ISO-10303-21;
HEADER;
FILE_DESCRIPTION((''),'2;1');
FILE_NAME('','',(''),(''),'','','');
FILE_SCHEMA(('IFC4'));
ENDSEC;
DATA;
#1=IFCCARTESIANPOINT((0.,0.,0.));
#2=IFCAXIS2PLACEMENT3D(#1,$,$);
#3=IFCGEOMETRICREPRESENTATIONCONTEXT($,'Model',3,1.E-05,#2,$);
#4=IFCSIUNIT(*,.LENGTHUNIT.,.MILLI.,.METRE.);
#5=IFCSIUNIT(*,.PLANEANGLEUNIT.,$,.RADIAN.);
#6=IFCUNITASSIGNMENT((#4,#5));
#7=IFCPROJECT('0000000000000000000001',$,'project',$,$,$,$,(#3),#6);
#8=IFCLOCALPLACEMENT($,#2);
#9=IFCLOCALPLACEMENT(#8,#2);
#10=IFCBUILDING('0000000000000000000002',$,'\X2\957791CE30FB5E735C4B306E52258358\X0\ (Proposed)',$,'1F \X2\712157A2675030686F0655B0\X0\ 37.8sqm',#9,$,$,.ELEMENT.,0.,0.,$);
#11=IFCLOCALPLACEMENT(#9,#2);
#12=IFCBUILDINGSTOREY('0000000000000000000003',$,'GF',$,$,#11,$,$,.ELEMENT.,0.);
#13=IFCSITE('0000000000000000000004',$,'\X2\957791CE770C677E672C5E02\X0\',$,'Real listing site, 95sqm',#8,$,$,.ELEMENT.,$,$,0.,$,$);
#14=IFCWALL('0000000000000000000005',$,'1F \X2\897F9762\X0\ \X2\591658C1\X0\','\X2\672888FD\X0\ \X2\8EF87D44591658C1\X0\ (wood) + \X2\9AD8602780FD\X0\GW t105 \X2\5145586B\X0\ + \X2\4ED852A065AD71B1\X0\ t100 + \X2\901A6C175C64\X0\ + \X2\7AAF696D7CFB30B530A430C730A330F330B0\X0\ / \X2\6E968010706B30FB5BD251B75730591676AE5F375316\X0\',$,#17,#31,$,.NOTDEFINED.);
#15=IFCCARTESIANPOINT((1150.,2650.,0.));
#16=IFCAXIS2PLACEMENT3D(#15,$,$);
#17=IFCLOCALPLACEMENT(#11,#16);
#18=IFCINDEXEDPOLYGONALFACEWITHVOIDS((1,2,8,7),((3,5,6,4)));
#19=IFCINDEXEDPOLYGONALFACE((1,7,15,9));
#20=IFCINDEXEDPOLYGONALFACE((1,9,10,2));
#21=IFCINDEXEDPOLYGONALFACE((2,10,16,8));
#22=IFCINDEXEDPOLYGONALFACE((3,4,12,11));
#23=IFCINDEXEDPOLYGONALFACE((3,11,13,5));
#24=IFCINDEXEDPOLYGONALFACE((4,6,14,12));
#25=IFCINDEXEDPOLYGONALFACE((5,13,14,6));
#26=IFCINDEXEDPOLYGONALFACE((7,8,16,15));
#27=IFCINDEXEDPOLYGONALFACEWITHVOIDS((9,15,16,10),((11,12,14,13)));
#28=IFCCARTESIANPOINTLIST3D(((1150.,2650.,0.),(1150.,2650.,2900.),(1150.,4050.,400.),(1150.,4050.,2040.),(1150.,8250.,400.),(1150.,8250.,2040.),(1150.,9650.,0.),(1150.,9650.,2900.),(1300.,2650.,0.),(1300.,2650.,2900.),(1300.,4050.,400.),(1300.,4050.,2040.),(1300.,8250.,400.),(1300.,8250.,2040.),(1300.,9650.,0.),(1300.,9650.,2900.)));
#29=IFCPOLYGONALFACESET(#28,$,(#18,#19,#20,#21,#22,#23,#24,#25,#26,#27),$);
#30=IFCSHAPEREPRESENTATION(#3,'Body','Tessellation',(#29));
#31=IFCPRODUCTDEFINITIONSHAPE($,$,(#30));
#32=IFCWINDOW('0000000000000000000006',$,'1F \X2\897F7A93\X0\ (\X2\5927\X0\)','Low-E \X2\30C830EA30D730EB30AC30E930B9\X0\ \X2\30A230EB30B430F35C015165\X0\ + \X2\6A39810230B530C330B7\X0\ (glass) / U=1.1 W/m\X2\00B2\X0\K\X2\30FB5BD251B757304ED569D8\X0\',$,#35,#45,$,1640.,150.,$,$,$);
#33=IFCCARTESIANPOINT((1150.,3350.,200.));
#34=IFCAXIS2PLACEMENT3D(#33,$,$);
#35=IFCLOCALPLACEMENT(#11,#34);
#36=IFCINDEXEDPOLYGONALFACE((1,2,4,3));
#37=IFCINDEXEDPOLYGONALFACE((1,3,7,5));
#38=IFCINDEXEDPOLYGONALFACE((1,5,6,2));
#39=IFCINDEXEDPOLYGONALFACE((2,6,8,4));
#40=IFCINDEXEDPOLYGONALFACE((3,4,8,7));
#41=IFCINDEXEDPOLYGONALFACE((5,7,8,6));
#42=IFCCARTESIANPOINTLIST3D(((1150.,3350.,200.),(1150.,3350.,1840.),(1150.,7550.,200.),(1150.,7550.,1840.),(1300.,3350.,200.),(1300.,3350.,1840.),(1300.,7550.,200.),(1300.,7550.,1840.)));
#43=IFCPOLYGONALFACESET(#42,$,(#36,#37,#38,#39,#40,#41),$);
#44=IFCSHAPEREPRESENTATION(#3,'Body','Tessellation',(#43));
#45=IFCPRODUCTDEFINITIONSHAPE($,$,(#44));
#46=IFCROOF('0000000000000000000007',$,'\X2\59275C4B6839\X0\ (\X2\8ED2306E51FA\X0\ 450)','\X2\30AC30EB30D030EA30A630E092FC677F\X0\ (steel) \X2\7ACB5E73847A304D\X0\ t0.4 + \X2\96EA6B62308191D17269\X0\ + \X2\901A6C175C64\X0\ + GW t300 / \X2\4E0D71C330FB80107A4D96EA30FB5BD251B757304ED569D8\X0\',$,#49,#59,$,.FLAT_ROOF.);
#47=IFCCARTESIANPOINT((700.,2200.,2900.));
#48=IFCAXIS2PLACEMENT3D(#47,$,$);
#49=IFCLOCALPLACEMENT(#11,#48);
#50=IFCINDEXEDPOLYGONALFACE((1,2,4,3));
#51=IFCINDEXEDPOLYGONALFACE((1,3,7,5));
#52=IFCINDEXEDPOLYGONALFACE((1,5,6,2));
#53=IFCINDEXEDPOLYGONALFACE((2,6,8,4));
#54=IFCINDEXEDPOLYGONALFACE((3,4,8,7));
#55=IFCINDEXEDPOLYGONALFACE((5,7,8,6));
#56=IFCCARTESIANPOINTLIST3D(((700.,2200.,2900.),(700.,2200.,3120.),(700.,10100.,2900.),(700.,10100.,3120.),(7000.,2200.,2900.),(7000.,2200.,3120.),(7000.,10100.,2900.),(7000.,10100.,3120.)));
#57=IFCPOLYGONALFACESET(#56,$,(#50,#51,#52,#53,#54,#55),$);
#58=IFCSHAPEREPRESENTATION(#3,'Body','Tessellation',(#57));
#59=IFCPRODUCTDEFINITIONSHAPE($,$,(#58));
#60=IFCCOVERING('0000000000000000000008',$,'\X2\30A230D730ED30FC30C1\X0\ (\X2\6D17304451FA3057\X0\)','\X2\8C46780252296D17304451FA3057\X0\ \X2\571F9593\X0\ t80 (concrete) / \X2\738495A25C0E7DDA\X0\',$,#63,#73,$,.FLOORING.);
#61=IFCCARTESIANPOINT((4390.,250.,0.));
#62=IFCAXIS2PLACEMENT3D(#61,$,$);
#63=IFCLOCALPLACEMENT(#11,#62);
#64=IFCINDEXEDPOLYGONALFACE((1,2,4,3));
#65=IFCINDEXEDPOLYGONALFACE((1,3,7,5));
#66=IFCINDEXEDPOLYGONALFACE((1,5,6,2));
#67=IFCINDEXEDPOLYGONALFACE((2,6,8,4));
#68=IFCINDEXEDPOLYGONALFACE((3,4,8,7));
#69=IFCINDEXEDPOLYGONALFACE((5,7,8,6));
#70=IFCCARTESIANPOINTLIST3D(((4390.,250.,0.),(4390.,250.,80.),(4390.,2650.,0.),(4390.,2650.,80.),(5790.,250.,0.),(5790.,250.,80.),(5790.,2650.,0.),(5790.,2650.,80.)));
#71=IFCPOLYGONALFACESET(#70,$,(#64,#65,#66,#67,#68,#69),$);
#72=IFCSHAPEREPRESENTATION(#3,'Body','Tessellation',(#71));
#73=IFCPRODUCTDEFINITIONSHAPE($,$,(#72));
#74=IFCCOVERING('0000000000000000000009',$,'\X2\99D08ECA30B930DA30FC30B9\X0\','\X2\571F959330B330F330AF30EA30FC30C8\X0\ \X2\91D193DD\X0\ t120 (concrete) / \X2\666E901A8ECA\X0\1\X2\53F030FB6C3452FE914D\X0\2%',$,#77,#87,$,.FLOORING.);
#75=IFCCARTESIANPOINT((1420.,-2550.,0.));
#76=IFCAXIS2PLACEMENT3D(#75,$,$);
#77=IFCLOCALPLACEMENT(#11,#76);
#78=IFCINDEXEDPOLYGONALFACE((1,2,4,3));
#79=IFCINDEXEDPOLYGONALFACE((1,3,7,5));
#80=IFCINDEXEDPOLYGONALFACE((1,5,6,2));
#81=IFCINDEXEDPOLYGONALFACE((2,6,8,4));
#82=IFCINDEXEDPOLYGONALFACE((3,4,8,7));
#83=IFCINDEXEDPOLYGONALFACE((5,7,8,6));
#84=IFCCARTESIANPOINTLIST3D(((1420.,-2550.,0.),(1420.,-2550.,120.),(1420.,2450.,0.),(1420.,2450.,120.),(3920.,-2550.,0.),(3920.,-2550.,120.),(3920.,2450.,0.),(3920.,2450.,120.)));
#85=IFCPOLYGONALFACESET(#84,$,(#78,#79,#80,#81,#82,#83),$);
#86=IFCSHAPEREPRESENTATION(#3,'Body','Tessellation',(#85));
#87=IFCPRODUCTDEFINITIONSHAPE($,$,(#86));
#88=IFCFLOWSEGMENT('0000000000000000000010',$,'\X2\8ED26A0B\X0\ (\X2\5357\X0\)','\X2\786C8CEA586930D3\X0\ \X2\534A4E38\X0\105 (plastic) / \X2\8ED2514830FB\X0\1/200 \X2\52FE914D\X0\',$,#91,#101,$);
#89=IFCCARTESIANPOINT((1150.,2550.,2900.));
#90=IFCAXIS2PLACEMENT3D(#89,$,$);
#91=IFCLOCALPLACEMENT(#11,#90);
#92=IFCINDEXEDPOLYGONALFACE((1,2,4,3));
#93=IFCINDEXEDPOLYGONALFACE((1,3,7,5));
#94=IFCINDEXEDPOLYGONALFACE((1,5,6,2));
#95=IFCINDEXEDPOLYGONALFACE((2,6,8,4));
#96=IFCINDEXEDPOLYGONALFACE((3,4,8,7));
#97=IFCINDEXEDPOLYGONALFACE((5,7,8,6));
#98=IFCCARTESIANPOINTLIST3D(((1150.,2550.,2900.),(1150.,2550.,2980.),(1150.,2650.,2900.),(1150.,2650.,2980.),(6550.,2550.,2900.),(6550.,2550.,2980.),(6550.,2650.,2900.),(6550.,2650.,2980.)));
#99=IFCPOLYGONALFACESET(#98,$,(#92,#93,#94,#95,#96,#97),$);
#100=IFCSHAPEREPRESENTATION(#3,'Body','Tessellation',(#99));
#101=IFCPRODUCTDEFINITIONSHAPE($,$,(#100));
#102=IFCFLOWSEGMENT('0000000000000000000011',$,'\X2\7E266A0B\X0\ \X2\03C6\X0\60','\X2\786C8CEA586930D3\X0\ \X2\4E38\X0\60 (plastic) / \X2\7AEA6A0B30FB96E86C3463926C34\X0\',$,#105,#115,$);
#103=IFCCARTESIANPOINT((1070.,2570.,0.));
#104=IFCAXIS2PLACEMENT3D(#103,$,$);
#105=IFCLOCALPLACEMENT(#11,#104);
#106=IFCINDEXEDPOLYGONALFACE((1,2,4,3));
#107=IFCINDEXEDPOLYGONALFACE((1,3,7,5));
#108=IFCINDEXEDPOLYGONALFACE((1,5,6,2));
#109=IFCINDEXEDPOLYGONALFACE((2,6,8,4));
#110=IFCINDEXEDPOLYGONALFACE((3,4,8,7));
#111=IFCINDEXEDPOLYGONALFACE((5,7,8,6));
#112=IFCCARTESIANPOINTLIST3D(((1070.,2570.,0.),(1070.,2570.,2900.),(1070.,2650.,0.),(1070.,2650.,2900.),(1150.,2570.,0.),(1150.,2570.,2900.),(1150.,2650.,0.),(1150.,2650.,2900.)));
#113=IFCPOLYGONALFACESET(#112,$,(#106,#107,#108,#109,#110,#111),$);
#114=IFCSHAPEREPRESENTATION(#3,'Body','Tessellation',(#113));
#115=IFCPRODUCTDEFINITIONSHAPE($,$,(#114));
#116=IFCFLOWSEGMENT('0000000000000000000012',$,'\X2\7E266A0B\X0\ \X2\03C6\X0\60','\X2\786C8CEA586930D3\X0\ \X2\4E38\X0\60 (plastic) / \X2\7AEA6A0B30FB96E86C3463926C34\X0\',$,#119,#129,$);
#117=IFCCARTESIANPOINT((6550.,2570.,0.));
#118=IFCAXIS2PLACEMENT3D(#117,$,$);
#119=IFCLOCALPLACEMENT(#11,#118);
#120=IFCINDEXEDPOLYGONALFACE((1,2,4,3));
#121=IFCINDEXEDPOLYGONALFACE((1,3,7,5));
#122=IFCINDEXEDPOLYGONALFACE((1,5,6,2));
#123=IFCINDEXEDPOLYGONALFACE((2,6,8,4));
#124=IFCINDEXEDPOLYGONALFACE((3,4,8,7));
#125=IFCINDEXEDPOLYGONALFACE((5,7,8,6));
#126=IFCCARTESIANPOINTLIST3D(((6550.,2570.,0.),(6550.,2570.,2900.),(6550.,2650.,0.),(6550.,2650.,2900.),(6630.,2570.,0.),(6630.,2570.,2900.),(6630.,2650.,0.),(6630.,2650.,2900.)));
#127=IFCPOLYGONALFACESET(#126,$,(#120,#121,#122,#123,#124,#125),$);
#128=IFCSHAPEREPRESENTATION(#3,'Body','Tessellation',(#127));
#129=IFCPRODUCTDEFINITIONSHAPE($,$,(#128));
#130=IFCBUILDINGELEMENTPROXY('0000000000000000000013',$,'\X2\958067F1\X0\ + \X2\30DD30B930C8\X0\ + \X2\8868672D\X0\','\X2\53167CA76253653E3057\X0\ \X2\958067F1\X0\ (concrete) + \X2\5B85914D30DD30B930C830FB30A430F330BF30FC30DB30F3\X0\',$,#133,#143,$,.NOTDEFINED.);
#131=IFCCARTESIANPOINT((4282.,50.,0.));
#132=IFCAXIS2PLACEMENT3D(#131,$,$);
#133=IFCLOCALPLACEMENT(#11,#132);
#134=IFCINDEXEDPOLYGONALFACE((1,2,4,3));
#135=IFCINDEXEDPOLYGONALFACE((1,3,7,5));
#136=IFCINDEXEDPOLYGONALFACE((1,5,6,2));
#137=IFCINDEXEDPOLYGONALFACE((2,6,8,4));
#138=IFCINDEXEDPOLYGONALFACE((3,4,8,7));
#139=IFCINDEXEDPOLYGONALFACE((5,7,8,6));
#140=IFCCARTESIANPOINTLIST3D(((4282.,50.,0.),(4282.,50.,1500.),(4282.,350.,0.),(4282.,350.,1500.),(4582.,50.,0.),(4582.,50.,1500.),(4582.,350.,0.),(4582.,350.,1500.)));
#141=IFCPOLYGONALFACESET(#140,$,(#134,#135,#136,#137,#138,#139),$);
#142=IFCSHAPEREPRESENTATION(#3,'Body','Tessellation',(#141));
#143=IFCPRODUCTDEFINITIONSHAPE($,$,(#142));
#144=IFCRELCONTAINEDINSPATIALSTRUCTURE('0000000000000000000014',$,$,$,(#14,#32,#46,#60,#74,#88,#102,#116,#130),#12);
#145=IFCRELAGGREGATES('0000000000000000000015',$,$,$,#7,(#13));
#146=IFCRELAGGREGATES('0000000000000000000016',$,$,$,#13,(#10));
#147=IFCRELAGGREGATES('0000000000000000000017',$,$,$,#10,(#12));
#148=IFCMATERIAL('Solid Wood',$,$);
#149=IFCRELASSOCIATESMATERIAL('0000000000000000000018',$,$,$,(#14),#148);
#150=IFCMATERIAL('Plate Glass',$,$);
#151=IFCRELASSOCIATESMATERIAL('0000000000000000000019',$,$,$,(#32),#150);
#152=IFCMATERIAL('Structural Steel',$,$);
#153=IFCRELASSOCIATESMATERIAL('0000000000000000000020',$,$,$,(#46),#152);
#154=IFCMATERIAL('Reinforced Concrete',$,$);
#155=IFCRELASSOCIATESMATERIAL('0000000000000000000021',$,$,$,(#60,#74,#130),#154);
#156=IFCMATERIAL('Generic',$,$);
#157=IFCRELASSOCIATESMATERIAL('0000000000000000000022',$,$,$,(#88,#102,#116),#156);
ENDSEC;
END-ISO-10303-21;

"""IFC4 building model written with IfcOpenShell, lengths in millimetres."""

from ifc_helpers import new_model, si_unit, frame, frame_2d, origin, place, context, project, spatial, rectangle, extrude, material, element, fill, save


model = new_model("IFC4")

# Units and contexts
model_context = context("Model", 3, precision=1e-05, world=origin())
ifc_project = project(units=[si_unit("LENGTHUNIT", "METRE", prefix="MILLI"), si_unit("PLANEANGLEUNIT", "RADIAN")], contexts=[model_context])

# Site, building, storey
site_placement = place(None, origin())
site = spatial("IfcSite", under=ifc_project, at=site_placement, Name="長野県松本市", ObjectType="Real listing site, 95sqm", CompositionType="ELEMENT", RefElevation=0.0)
building_placement = place(site_placement, origin())
building = spatial("IfcBuilding", under=site, at=building_placement, Name="長野・平屋の別荘 (Proposed)", ObjectType="1F 無垢材と漆喰 37.8sqm", CompositionType="ELEMENT", ElevationOfRefHeight=0.0, ElevationOfTerrain=0.0)
storey_placement = place(building_placement, origin())
storey = spatial("IfcBuildingStorey", under=building, at=storey_placement, Name="GF", CompositionType="ELEMENT", Elevation=0.0)

# Shared definitions
ifc_material_1 = material(Name="Solid Wood")

# Shared definitions
ifc_material_2 = material(Name="Reinforced Concrete")

# Shared definitions
ifc_material_3 = material(Name="Plate Glass")

# Wall, opening, window
wall_1_placement = place(storey_placement, frame((1150.0, 2650.0, 0.0)))
wall_1 = element("IfcWall", 1, at=wall_1_placement, inside=storey, material=ifc_material_1, Name="1F 西面 外壁", Description="木製 軸組外壁 (wood) + 高性能GW t105 充填 + 付加断熱 t100 + 通気層 + 窯業系サイディング / 準耐火・寒冷地外皮強化", PredefinedType="NOTDEFINED", context=model_context, shape_type="SweptSolid", body=[
    extrude(rectangle(XDim=150.0, YDim=7000.0, at=frame_2d((75.0, 3500.0))), frame((1150.0, 2650.0, 0.0)), (0.0, 0.0, 1.0), 2900.0),
])
opening_1_placement = place(storey_placement, frame((1150.0, 3350.0, 200.0)))
opening_1 = element("IfcOpeningElement", 2, at=opening_1_placement, cuts=wall_1, PredefinedType="NOTDEFINED", context=model_context, shape_type="SweptSolid", body=[
    extrude(rectangle(XDim=150.0, YDim=4200.0, at=frame_2d((75.0, 2100.0))), frame((1150.0, 3350.0, 200.0)), (0.0, 0.0, 1.0), 1640.0),
])
window_1_placement = place(storey_placement, frame((1150.0, 3350.0, 200.0)))
window_1 = element("IfcWindow", 3, at=window_1_placement, inside=storey, material=ifc_material_3, Name="1F 西窓 (大)", Description="Low-E トリプルガラス アルゴン封入 + 樹脂サッシ (glass) / U=1.1 W/m²K・寒冷地仕様", OverallHeight=1640.0, OverallWidth=150.0, context=model_context, shape_type="SweptSolid", body=[
    extrude(rectangle(XDim=150.0, YDim=4200.0, at=frame_2d((75.0, 2100.0))), frame((1150.0, 3350.0, 200.0)), (0.0, 0.0, 1.0), 1640.0),
])
fill(opening_1, window_1)

# Roof
ifc_material_4 = material(Name="Structural Steel")
roof_placement = place(storey_placement, frame((700.0, 2200.0, 2900.0)))
element("IfcRoof", 4, at=roof_placement, inside=storey, material=ifc_material_4, Name="大屋根 (軒の出 450)", Description="ガルバリウム鋼板 (steel) 立平葺き t0.4 + 雪止め金物 + 通気層 + GW t300 / 不燃・耐積雪・寒冷地仕様", PredefinedType="FLAT_ROOF", context=model_context, shape_type="SweptSolid", body=[
    extrude(rectangle(XDim=6300.0, YDim=7900.0, at=frame_2d((3150.0, 3950.0))), frame((700.0, 2200.0, 2900.0)), (0.0, 0.0, 1.0), 220.0),
])

# Coverings
covering_1_placement = place(storey_placement, frame((4390.0, 250.0, 0.0)))
element("IfcCovering", 5, at=covering_1_placement, inside=storey, material=ifc_material_2, Name="アプローチ (洗い出し)", Description="豆砂利洗い出し 土間 t80 (concrete) / 玄関導線", PredefinedType="FLOORING", context=model_context, shape_type="SweptSolid", body=[
    extrude(rectangle(XDim=1400.0, YDim=2400.0, at=frame_2d((700.0, 1200.0))), frame((4390.0, 250.0, 0.0)), (0.0, 0.0, 1.0), 80.0),
])
covering_2_placement = place(storey_placement, frame((1420.0, -2550.0, 0.0)))
element("IfcCovering", 6, at=covering_2_placement, inside=storey, material=ifc_material_2, Name="駐車スペース", Description="土間コンクリート 金鏝 t120 (concrete) / 普通車1台・水勾配2%", PredefinedType="FLOORING", context=model_context, shape_type="SweptSolid", body=[
    extrude(rectangle(XDim=2500.0, YDim=5000.0, at=frame_2d((1250.0, 2500.0))), frame((1420.0, -2550.0, 0.0)), (0.0, 0.0, 1.0), 120.0),
])

# Flow segments
ifc_material_5 = material(Name="Generic")
flow_segment_1_placement = place(storey_placement, frame((1150.0, 2550.0, 2900.0)))
element("IfcFlowSegment", 7, at=flow_segment_1_placement, inside=storey, material=ifc_material_5, Name="軒樋 (南)", Description="硬質塩ビ 半丸105 (plastic) / 軒先・1/200 勾配", context=model_context, shape_type="SweptSolid", body=[
    extrude(rectangle(XDim=5400.0, YDim=100.0, at=frame_2d((2700.0, 50.0))), frame((1150.0, 2550.0, 2900.0)), (0.0, 0.0, 1.0), 80.0),
])
flow_segment_2_placement = place(storey_placement, frame((1070.0, 2570.0, 0.0)))
element("IfcFlowSegment", 8, at=flow_segment_2_placement, inside=storey, material=ifc_material_5, Name="縦樋 φ60", Description="硬質塩ビ 丸60 (plastic) / 竪樋・雨水排水", context=model_context, shape_type="SweptSolid", body=[
    extrude(rectangle(XDim=80.0, YDim=80.0, at=frame_2d((40.0, 40.0))), frame((1070.0, 2570.0, 0.0)), (0.0, 0.0, 1.0), 2900.0),
])
flow_segment_3_placement = place(storey_placement, frame((6550.0, 2570.0, 0.0)))
element("IfcFlowSegment", 9, at=flow_segment_3_placement, inside=storey, material=ifc_material_5, Name="縦樋 φ60", Description="硬質塩ビ 丸60 (plastic) / 竪樋・雨水排水", context=model_context, shape_type="SweptSolid", body=[
    extrude(rectangle(XDim=80.0, YDim=80.0, at=frame_2d((40.0, 40.0))), frame((6550.0, 2570.0, 0.0)), (0.0, 0.0, 1.0), 2900.0),
])

# Building element proxy
proxy_placement = place(storey_placement, frame((4282.0, 50.0, 0.0)))
element("IfcBuildingElementProxy", 10, at=proxy_placement, inside=storey, material=ifc_material_2, Name="門柱 + ポスト + 表札", Description="化粧打放し 門柱 (concrete) + 宅配ポスト・インターホン", PredefinedType="NOTDEFINED", context=model_context, shape_type="SweptSolid", body=[
    extrude(rectangle(XDim=300.0, YDim=300.0, at=frame_2d((150.0, 150.0))), frame((4282.0, 50.0, 0.0)), (0.0, 0.0, 1.0), 1500.0),
])

save(model, "model.ifc")
